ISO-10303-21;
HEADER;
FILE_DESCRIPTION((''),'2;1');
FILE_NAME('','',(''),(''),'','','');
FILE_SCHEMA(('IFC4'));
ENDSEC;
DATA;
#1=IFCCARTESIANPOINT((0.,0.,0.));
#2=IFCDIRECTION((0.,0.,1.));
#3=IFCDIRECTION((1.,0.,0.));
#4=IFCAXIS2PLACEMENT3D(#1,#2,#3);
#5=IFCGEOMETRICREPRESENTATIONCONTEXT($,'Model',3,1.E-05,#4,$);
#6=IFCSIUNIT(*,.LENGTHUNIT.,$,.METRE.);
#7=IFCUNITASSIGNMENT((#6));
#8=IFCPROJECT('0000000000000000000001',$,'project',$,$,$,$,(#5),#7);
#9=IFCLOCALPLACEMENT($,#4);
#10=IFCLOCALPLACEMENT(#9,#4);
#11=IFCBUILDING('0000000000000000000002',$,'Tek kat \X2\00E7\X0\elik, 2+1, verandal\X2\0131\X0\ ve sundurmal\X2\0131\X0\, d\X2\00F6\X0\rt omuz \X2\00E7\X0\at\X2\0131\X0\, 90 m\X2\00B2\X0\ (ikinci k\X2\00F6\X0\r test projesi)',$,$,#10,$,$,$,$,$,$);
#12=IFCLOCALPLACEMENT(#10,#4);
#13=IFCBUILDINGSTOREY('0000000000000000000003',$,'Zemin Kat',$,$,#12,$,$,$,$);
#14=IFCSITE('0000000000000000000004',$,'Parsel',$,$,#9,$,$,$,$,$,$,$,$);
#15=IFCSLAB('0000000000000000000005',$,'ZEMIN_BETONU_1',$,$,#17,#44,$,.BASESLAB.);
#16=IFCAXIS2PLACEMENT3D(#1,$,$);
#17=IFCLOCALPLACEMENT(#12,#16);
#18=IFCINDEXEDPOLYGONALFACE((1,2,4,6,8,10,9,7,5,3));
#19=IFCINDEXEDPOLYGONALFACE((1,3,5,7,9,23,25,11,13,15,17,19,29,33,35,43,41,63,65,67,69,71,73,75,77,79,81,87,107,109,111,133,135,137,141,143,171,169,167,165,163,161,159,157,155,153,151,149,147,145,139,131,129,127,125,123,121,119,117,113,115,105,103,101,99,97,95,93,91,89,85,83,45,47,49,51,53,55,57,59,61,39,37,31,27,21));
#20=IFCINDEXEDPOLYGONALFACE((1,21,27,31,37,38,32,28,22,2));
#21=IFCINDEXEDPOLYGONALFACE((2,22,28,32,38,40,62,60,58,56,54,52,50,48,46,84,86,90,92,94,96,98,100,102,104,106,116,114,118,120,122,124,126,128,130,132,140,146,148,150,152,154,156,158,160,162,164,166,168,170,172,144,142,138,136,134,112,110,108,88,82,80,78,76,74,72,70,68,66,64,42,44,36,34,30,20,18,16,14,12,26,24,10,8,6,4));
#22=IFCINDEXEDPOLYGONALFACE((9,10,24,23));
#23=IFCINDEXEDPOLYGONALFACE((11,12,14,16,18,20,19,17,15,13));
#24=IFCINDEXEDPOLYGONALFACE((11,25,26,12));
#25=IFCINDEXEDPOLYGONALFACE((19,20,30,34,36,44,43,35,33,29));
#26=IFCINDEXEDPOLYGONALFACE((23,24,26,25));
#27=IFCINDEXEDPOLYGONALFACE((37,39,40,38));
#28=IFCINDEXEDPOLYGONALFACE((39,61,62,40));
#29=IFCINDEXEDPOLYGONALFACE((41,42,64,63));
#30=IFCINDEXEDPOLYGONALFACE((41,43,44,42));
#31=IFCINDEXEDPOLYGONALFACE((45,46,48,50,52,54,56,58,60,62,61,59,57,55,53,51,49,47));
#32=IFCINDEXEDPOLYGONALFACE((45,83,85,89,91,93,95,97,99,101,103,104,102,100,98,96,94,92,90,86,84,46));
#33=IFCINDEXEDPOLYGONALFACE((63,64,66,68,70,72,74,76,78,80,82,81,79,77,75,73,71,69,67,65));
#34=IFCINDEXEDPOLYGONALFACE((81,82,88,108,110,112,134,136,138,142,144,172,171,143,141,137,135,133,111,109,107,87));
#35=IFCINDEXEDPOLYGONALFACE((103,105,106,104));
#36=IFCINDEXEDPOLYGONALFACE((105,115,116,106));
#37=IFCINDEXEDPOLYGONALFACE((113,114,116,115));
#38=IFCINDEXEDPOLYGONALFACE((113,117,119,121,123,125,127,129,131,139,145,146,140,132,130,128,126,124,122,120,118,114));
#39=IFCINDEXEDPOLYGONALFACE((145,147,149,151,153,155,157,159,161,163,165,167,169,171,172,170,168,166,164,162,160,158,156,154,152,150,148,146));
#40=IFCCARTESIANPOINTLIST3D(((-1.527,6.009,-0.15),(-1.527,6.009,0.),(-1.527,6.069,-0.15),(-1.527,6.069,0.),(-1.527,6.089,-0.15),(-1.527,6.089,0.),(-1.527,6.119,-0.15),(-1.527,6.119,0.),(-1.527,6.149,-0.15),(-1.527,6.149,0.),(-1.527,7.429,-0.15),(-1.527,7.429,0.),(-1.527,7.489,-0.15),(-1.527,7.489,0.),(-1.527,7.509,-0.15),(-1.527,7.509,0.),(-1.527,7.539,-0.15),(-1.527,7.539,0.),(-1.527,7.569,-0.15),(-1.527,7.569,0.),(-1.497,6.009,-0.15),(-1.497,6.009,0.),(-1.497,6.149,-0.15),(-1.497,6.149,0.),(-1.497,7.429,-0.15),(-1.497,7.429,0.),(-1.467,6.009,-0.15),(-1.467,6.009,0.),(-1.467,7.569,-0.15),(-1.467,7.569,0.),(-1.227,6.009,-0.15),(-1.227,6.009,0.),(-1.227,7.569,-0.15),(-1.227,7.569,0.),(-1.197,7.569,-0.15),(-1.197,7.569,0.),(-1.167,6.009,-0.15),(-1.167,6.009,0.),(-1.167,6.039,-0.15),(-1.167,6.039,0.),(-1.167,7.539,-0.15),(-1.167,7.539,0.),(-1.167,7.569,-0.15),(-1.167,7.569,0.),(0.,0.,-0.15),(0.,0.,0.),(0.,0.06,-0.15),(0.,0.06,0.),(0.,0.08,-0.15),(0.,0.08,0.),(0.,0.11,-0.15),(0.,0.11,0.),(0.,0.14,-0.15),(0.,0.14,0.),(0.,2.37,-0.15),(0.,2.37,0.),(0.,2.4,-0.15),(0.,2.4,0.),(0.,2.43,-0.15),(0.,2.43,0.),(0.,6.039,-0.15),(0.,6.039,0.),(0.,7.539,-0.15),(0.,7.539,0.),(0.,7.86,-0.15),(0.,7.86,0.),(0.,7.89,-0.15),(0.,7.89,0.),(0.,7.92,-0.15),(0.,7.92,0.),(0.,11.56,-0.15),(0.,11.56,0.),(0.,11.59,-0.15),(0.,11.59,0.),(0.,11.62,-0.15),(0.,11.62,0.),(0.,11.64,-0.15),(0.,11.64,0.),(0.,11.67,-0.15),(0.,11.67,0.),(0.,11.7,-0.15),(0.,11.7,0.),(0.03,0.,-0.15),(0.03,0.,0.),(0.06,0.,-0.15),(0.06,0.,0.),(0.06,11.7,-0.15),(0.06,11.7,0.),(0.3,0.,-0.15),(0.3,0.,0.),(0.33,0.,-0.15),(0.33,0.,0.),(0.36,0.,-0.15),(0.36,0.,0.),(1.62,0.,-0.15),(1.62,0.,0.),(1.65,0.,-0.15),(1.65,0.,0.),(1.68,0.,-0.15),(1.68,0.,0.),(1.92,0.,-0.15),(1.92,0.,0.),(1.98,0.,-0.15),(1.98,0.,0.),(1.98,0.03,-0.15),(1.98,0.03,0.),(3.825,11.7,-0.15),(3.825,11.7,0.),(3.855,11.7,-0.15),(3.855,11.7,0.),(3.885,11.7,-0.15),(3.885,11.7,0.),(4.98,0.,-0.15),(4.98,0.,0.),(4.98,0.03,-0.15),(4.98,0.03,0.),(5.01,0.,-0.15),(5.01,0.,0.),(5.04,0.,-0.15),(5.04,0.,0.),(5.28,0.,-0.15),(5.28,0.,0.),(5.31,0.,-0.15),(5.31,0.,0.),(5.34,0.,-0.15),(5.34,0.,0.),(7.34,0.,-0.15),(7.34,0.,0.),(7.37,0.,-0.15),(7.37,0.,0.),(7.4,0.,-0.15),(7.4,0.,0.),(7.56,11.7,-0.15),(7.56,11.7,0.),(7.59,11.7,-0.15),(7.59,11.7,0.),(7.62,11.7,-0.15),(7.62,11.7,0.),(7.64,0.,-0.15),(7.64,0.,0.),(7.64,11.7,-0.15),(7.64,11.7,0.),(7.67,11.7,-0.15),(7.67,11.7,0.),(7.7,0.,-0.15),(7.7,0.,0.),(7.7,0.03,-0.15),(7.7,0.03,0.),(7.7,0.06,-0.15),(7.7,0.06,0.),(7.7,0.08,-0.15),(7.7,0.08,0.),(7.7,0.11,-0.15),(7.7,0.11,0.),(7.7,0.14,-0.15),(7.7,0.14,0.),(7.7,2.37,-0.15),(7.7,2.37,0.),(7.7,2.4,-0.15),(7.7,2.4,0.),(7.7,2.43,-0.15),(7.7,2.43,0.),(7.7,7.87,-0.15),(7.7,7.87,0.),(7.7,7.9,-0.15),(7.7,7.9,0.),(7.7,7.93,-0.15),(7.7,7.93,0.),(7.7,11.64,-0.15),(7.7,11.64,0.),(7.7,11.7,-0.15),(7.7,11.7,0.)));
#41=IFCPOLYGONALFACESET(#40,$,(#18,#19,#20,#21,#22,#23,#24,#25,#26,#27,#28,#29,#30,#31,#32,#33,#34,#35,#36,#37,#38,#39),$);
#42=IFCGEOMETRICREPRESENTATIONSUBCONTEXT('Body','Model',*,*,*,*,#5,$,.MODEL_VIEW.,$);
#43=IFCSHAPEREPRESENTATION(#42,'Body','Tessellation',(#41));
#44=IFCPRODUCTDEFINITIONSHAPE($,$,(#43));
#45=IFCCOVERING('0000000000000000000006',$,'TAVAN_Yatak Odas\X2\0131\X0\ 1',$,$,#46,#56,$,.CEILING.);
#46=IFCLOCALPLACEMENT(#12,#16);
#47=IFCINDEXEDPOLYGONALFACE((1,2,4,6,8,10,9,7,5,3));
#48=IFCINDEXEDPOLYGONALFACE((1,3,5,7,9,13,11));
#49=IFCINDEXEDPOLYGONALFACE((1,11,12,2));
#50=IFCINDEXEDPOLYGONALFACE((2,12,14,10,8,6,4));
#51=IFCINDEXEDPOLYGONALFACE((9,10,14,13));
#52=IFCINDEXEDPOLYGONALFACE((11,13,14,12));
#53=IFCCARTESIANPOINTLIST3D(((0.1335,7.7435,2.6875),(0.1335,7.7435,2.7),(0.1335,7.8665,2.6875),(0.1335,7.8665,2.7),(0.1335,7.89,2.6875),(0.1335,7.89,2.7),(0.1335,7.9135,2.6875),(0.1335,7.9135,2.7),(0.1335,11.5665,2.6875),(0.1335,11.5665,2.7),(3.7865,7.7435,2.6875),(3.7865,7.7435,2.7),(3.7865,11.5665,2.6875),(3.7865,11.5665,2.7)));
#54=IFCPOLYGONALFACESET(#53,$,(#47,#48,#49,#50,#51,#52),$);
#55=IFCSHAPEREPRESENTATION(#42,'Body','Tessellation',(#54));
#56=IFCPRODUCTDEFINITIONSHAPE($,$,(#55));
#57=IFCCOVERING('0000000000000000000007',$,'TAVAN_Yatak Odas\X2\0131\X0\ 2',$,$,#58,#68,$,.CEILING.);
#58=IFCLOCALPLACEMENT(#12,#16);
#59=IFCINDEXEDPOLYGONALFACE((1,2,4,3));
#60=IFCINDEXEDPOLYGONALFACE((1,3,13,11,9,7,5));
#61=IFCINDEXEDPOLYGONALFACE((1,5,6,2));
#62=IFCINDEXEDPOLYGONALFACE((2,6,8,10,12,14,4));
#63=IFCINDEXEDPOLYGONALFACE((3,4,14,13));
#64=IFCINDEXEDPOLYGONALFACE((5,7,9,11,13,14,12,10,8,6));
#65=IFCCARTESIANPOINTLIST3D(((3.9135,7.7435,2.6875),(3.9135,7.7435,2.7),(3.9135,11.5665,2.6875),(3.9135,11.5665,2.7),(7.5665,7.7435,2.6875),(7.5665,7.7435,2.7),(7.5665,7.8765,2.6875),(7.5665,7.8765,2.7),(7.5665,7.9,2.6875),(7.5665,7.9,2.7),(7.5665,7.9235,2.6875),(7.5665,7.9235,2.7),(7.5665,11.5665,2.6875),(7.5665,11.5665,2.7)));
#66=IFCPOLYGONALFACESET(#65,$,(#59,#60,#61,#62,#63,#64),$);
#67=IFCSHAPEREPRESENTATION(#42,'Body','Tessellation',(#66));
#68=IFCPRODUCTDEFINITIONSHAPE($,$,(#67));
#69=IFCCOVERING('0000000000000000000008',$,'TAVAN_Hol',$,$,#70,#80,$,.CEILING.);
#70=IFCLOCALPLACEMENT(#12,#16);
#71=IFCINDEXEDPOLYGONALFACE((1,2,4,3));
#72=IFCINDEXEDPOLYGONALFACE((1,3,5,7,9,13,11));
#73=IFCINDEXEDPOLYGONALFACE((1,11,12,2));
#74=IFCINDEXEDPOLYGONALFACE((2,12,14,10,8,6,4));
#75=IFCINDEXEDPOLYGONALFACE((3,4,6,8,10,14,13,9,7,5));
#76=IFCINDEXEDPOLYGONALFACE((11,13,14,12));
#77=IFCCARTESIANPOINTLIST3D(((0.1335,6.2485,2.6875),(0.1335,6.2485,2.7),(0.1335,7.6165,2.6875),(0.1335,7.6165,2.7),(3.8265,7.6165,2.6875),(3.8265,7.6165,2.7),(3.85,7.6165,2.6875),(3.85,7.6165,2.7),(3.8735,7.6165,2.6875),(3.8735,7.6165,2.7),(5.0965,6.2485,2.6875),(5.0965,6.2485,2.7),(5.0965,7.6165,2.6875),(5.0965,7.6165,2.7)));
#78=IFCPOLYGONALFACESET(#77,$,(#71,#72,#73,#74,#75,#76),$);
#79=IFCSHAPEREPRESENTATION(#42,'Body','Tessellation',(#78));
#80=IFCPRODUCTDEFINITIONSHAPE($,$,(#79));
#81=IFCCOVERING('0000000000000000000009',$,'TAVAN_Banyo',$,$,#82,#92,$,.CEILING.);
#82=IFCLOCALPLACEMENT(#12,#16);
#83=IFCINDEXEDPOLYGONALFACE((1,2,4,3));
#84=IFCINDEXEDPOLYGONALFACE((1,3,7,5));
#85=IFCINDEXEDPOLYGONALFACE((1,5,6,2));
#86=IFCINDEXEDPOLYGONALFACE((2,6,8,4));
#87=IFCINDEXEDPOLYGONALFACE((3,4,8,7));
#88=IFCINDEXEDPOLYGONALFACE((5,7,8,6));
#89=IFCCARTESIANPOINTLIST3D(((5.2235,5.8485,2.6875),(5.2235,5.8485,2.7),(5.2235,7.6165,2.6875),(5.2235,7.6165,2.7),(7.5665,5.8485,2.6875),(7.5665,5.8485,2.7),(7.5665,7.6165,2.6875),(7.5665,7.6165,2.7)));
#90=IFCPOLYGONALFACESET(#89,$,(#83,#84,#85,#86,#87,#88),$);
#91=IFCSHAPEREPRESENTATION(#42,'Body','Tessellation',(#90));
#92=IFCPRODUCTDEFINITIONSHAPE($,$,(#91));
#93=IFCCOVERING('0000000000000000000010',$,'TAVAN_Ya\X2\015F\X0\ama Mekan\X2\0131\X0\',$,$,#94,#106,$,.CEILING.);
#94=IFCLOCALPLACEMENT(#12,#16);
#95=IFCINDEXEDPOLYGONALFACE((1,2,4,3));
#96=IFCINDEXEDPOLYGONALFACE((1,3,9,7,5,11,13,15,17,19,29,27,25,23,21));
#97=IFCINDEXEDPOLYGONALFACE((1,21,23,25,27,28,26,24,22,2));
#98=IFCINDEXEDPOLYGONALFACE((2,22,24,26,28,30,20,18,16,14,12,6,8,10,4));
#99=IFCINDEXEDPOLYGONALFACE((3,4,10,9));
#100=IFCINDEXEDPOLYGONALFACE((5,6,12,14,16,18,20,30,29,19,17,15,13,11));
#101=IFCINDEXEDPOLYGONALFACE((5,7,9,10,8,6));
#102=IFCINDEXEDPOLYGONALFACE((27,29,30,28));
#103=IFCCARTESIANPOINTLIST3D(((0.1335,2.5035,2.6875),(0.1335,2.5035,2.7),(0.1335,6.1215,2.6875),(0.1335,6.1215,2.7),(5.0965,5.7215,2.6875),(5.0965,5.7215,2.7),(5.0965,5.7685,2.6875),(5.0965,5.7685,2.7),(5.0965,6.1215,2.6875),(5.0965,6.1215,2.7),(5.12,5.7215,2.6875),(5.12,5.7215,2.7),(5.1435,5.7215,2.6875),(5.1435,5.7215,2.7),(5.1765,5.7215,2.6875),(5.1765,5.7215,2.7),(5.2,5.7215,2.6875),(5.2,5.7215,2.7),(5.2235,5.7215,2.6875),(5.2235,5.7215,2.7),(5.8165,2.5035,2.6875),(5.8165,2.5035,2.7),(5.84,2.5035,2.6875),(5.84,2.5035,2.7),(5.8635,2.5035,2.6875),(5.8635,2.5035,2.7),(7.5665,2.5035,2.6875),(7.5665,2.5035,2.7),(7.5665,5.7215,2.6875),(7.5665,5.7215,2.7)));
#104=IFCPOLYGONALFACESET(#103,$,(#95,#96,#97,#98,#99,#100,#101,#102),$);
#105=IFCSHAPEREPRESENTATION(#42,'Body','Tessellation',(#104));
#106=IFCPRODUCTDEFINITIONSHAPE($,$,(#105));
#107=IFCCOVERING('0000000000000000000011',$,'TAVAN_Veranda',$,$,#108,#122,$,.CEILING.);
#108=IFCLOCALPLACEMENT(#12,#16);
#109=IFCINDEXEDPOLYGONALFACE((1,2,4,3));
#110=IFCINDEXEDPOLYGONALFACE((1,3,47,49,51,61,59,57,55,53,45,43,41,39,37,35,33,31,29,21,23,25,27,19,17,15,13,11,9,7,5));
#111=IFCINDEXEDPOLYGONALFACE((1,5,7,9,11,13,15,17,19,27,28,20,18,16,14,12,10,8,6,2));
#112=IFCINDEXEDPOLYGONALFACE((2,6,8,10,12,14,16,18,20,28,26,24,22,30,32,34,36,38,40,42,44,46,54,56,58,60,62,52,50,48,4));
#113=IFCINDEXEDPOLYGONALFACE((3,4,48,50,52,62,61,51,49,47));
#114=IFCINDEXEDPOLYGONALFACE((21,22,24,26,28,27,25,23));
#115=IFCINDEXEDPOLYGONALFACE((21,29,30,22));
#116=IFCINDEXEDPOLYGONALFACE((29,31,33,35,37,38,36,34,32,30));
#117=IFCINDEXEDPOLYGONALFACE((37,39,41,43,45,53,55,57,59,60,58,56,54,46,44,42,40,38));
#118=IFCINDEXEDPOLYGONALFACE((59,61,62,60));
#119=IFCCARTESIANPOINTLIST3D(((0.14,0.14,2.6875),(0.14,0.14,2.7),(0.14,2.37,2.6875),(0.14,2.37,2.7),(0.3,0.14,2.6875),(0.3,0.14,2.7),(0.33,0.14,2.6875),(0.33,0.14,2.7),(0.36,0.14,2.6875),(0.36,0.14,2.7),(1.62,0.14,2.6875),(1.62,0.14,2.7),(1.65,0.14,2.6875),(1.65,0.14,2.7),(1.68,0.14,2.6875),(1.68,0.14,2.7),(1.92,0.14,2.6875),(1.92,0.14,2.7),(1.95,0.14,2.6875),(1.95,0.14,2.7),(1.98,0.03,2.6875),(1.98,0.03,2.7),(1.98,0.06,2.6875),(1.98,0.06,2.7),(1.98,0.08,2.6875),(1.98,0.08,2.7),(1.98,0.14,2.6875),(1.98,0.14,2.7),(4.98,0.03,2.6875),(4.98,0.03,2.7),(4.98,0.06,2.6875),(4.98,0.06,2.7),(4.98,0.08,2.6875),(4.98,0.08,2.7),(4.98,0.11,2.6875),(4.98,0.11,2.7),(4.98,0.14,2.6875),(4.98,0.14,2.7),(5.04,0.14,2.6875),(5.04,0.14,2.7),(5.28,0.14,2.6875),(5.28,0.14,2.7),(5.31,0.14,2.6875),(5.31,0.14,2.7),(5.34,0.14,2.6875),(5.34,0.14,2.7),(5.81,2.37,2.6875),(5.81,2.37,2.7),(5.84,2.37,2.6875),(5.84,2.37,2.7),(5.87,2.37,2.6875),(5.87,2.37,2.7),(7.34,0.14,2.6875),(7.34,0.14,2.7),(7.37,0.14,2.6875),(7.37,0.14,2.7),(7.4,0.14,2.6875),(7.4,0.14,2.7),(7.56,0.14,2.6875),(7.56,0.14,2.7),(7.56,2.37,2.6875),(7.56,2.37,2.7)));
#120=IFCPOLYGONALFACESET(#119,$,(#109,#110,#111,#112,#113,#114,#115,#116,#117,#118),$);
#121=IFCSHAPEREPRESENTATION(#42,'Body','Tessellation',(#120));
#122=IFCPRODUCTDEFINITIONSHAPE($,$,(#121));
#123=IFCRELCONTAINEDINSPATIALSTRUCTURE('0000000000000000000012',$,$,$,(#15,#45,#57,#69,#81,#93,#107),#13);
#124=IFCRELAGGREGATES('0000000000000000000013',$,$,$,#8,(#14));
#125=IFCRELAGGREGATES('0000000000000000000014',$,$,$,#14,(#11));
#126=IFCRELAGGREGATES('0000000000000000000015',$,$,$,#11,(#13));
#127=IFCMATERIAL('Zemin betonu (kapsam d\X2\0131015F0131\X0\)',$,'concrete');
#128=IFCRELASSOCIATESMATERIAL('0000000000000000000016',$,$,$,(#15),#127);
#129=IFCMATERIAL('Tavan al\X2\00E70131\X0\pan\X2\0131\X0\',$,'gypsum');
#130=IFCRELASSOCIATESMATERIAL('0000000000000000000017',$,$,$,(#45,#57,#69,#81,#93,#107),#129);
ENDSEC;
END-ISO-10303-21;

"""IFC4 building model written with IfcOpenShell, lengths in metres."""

from ifc_helpers import new_model, si_unit, frame, origin_with_axes, place, context, subcontext, project, spatial, line, indexed_curve, outline, extrude, material, element, save


model = new_model("IFC4")

# Units and contexts
model_context = context("Model", 3, precision=1e-05, world=origin_with_axes())
body_context = subcontext(model_context, "Body", "Model", "MODEL_VIEW")
ifc_project = project(units=[si_unit("LENGTHUNIT", "METRE")], contexts=[model_context])

# Site, building, storey
site_placement = place(None, origin_with_axes())
site = spatial("IfcSite", under=ifc_project, at=site_placement, Name="Parsel")
building_placement = place(site_placement, origin_with_axes())
building = spatial("IfcBuilding", under=site, at=building_placement, Name="Tek kat çelik, 2+1, verandalı ve sundurmalı, dört omuz çatı, 90 m² (ikinci kör test projesi)")
storey_placement = place(building_placement, origin_with_axes())
storey = spatial("IfcBuildingStorey", under=building, at=storey_placement, Name="Zemin Kat")

# Slab
ifc_material_1 = material(Name="Zemin betonu (kapsam dışı)", Category="concrete")
slab_placement = place(storey_placement, origin_with_axes())
element("IfcSlab", 1, at=slab_placement, inside=storey, material=ifc_material_1, Name="ZEMIN_BETONU_1", PredefinedType="BASESLAB", context=body_context, shape_type="SweptSolid", body=[
    extrude(outline(indexed_curve([(4.98, 0.03), (4.98, 0.0), (5.01, 0.0), (5.04, 0.0), (5.28, 0.0), (5.31, 0.0), (5.34, 0.0), (7.34, 0.0), (7.37, 0.0), (7.4, 0.0), (7.64, 0.0), (7.7, 0.0), (7.7, 0.03), (7.7, 0.06), (7.7, 0.08), (7.7, 0.11), (7.7, 0.14), (7.7, 2.37), (7.7, 2.4), (7.7, 2.43), (7.7, 7.87), (7.7, 7.9), (7.7, 7.93), (7.7, 11.64), (7.7, 11.7), (7.67, 11.7), (7.64, 11.7), (7.62, 11.7), (7.59, 11.7), (7.56, 11.7), (3.885, 11.7), (3.855, 11.7), (3.825, 11.7), (0.06, 11.7), (0.0, 11.7), (0.0, 11.67), (0.0, 11.64), (0.0, 11.62), (0.0, 11.59), (0.0, 11.56), (0.0, 7.92), (0.0, 7.89), (0.0, 7.86), (0.0, 7.539), (-1.167, 7.539), (-1.167, 7.569), (-1.197, 7.569), (-1.227, 7.569), (-1.467, 7.569), (-1.527, 7.569), (-1.527, 7.539), (-1.527, 7.509), (-1.527, 7.489), (-1.527, 7.429), (-1.497, 7.429), (-1.497, 6.149), (-1.527, 6.149), (-1.527, 6.119), (-1.527, 6.089), (-1.527, 6.069), (-1.527, 6.009), (-1.497, 6.009), (-1.467, 6.009), (-1.227, 6.009), (-1.167, 6.009), (-1.167, 6.039), (0.0, 6.039), (0.0, 2.43), (0.0, 2.4), (0.0, 2.37), (0.0, 0.14), (0.0, 0.11), (0.0, 0.08), (0.0, 0.06), (0.0, 0.0), (0.03, 0.0), (0.06, 0.0), (0.3, 0.0), (0.33, 0.0), (0.36, 0.0), (1.62, 0.0), (1.65, 0.0), (1.68, 0.0), (1.92, 0.0), (1.98, 0.0), (1.98, 0.03)], segments=[line(1, 2, 3, 4, 5, 6, 7, 8, 9, 10, 11, 12, 13, 14, 15, 16, 17, 18, 19, 20, 21, 22, 23, 24, 25, 26, 27, 28, 29, 30, 31, 32, 33, 34, 35, 36, 37, 38, 39, 40, 41, 42, 43, 44, 45, 46, 47, 48, 49, 50, 51, 52, 53, 54, 55, 56, 57, 58, 59, 60, 61, 62, 63, 64, 65, 66, 67, 68, 69, 70, 71, 72, 73, 74, 75, 76, 77, 78, 79, 80, 81, 82, 83, 84, 85, 86, 1)])), frame((0.0, 0.0, -0.15), z_axis=(0.0, 0.0, 1.0), x_axis=(1.0, 0.0, 0.0)), (0.0, 0.0, 1.0), 0.15),
])

# Coverings
ifc_material_2 = material(Name="Tavan alçıpanı", Category="gypsum")
covering_1_placement = place(storey_placement, origin_with_axes())
element("IfcCovering", 2, at=covering_1_placement, inside=storey, material=ifc_material_2, Name="TAVAN_Yatak Odası 1", PredefinedType="CEILING", context=body_context, shape_type="SweptSolid", body=[
    extrude(outline(indexed_curve([(0.1335, 11.5665), (3.7865, 11.5665), (3.7865, 7.7435), (0.1335, 7.7435), (0.1335, 7.8665), (0.1335, 7.89), (0.1335, 7.9135)], segments=[line(1, 2, 3, 4, 5, 6, 7, 1)])), frame((0.0, 0.0, 2.6875), z_axis=(0.0, 0.0, 1.0), x_axis=(1.0, 0.0, 0.0)), (0.0, 0.0, 1.0), 0.0125),
])
covering_2_placement = place(storey_placement, origin_with_axes())
element("IfcCovering", 3, at=covering_2_placement, inside=storey, material=ifc_material_2, Name="TAVAN_Yatak Odası 2", PredefinedType="CEILING", context=body_context, shape_type="SweptSolid", body=[
    extrude(outline(indexed_curve([(3.9135, 11.5665), (7.5665, 11.5665), (7.5665, 7.9235), (7.5665, 7.9), (7.5665, 7.8765), (7.5665, 7.7435), (3.9135, 7.7435)], segments=[line(1, 2, 3, 4, 5, 6, 7, 1)])), frame((0.0, 0.0, 2.6875), z_axis=(0.0, 0.0, 1.0), x_axis=(1.0, 0.0, 0.0)), (0.0, 0.0, 1.0), 0.0125),
])
covering_3_placement = place(storey_placement, origin_with_axes())
element("IfcCovering", 4, at=covering_3_placement, inside=storey, material=ifc_material_2, Name="TAVAN_Hol", PredefinedType="CEILING", context=body_context, shape_type="SweptSolid", body=[
    extrude(outline(indexed_curve([(3.8735, 7.6165), (5.0965, 7.6165), (5.0965, 6.2485), (0.1335, 6.2485), (0.1335, 7.6165), (3.8265, 7.6165), (3.85, 7.6165)], segments=[line(1, 2, 3, 4, 5, 6, 7, 1)])), frame((0.0, 0.0, 2.6875), z_axis=(0.0, 0.0, 1.0), x_axis=(1.0, 0.0, 0.0)), (0.0, 0.0, 1.0), 0.0125),
])
covering_4_placement = place(storey_placement, origin_with_axes())
element("IfcCovering", 5, at=covering_4_placement, inside=storey, material=ifc_material_2, Name="TAVAN_Banyo", PredefinedType="CEILING", context=body_context, shape_type="SweptSolid", body=[
    extrude(outline(indexed_curve([(5.2235, 7.6165), (7.5665, 7.6165), (7.5665, 5.8485), (5.2235, 5.8485)], segments=[line(1, 2, 3, 4, 1)])), frame((0.0, 0.0, 2.6875), z_axis=(0.0, 0.0, 1.0), x_axis=(1.0, 0.0, 0.0)), (0.0, 0.0, 1.0), 0.0125),
])
covering_5_placement = place(storey_placement, origin_with_axes())
element("IfcCovering", 6, at=covering_5_placement, inside=storey, material=ifc_material_2, Name="TAVAN_Yaşama Mekanı", PredefinedType="CEILING", context=body_context, shape_type="SweptSolid", body=[
    extrude(outline(indexed_curve([(5.2235, 5.7215), (7.5665, 5.7215), (7.5665, 2.5035), (5.8635, 2.5035), (5.84, 2.5035), (5.8165, 2.5035), (0.1335, 2.5035), (0.1335, 6.1215), (5.0965, 6.1215), (5.0965, 5.7685), (5.0965, 5.7215), (5.12, 5.7215), (5.1435, 5.7215), (5.1765, 5.7215), (5.2, 5.7215)], segments=[line(1, 2, 3, 4, 5, 6, 7, 8, 9, 10, 11, 12, 13, 14, 15, 1)])), frame((0.0, 0.0, 2.6875), z_axis=(0.0, 0.0, 1.0), x_axis=(1.0, 0.0, 0.0)), (0.0, 0.0, 1.0), 0.0125),
])
covering_6_placement = place(storey_placement, origin_with_axes())
element("IfcCovering", 7, at=covering_6_placement, inside=storey, material=ifc_material_2, Name="TAVAN_Veranda", PredefinedType="CEILING", context=body_context, shape_type="SweptSolid", body=[
    extrude(outline(indexed_curve([(1.98, 0.03), (1.98, 0.06), (1.98, 0.08), (1.98, 0.14), (1.95, 0.14), (1.92, 0.14), (1.68, 0.14), (1.65, 0.14), (1.62, 0.14), (0.36, 0.14), (0.33, 0.14), (0.3, 0.14), (0.14, 0.14), (0.14, 2.37), (5.81, 2.37), (5.84, 2.37), (5.87, 2.37), (7.56, 2.37), (7.56, 0.14), (7.4, 0.14), (7.37, 0.14), (7.34, 0.14), (5.34, 0.14), (5.31, 0.14), (5.28, 0.14), (5.04, 0.14), (4.98, 0.14), (4.98, 0.11), (4.98, 0.08), (4.98, 0.06), (4.98, 0.03)], segments=[line(1, 2, 3, 4, 5, 6, 7, 8, 9, 10, 11, 12, 13, 14, 15, 16, 17, 18, 19, 20, 21, 22, 23, 24, 25, 26, 27, 28, 29, 30, 31, 1)])), frame((0.0, 0.0, 2.6875), z_axis=(0.0, 0.0, 1.0), x_axis=(1.0, 0.0, 0.0)), (0.0, 0.0, 1.0), 0.0125),
])

save(model, "model.ifc")
